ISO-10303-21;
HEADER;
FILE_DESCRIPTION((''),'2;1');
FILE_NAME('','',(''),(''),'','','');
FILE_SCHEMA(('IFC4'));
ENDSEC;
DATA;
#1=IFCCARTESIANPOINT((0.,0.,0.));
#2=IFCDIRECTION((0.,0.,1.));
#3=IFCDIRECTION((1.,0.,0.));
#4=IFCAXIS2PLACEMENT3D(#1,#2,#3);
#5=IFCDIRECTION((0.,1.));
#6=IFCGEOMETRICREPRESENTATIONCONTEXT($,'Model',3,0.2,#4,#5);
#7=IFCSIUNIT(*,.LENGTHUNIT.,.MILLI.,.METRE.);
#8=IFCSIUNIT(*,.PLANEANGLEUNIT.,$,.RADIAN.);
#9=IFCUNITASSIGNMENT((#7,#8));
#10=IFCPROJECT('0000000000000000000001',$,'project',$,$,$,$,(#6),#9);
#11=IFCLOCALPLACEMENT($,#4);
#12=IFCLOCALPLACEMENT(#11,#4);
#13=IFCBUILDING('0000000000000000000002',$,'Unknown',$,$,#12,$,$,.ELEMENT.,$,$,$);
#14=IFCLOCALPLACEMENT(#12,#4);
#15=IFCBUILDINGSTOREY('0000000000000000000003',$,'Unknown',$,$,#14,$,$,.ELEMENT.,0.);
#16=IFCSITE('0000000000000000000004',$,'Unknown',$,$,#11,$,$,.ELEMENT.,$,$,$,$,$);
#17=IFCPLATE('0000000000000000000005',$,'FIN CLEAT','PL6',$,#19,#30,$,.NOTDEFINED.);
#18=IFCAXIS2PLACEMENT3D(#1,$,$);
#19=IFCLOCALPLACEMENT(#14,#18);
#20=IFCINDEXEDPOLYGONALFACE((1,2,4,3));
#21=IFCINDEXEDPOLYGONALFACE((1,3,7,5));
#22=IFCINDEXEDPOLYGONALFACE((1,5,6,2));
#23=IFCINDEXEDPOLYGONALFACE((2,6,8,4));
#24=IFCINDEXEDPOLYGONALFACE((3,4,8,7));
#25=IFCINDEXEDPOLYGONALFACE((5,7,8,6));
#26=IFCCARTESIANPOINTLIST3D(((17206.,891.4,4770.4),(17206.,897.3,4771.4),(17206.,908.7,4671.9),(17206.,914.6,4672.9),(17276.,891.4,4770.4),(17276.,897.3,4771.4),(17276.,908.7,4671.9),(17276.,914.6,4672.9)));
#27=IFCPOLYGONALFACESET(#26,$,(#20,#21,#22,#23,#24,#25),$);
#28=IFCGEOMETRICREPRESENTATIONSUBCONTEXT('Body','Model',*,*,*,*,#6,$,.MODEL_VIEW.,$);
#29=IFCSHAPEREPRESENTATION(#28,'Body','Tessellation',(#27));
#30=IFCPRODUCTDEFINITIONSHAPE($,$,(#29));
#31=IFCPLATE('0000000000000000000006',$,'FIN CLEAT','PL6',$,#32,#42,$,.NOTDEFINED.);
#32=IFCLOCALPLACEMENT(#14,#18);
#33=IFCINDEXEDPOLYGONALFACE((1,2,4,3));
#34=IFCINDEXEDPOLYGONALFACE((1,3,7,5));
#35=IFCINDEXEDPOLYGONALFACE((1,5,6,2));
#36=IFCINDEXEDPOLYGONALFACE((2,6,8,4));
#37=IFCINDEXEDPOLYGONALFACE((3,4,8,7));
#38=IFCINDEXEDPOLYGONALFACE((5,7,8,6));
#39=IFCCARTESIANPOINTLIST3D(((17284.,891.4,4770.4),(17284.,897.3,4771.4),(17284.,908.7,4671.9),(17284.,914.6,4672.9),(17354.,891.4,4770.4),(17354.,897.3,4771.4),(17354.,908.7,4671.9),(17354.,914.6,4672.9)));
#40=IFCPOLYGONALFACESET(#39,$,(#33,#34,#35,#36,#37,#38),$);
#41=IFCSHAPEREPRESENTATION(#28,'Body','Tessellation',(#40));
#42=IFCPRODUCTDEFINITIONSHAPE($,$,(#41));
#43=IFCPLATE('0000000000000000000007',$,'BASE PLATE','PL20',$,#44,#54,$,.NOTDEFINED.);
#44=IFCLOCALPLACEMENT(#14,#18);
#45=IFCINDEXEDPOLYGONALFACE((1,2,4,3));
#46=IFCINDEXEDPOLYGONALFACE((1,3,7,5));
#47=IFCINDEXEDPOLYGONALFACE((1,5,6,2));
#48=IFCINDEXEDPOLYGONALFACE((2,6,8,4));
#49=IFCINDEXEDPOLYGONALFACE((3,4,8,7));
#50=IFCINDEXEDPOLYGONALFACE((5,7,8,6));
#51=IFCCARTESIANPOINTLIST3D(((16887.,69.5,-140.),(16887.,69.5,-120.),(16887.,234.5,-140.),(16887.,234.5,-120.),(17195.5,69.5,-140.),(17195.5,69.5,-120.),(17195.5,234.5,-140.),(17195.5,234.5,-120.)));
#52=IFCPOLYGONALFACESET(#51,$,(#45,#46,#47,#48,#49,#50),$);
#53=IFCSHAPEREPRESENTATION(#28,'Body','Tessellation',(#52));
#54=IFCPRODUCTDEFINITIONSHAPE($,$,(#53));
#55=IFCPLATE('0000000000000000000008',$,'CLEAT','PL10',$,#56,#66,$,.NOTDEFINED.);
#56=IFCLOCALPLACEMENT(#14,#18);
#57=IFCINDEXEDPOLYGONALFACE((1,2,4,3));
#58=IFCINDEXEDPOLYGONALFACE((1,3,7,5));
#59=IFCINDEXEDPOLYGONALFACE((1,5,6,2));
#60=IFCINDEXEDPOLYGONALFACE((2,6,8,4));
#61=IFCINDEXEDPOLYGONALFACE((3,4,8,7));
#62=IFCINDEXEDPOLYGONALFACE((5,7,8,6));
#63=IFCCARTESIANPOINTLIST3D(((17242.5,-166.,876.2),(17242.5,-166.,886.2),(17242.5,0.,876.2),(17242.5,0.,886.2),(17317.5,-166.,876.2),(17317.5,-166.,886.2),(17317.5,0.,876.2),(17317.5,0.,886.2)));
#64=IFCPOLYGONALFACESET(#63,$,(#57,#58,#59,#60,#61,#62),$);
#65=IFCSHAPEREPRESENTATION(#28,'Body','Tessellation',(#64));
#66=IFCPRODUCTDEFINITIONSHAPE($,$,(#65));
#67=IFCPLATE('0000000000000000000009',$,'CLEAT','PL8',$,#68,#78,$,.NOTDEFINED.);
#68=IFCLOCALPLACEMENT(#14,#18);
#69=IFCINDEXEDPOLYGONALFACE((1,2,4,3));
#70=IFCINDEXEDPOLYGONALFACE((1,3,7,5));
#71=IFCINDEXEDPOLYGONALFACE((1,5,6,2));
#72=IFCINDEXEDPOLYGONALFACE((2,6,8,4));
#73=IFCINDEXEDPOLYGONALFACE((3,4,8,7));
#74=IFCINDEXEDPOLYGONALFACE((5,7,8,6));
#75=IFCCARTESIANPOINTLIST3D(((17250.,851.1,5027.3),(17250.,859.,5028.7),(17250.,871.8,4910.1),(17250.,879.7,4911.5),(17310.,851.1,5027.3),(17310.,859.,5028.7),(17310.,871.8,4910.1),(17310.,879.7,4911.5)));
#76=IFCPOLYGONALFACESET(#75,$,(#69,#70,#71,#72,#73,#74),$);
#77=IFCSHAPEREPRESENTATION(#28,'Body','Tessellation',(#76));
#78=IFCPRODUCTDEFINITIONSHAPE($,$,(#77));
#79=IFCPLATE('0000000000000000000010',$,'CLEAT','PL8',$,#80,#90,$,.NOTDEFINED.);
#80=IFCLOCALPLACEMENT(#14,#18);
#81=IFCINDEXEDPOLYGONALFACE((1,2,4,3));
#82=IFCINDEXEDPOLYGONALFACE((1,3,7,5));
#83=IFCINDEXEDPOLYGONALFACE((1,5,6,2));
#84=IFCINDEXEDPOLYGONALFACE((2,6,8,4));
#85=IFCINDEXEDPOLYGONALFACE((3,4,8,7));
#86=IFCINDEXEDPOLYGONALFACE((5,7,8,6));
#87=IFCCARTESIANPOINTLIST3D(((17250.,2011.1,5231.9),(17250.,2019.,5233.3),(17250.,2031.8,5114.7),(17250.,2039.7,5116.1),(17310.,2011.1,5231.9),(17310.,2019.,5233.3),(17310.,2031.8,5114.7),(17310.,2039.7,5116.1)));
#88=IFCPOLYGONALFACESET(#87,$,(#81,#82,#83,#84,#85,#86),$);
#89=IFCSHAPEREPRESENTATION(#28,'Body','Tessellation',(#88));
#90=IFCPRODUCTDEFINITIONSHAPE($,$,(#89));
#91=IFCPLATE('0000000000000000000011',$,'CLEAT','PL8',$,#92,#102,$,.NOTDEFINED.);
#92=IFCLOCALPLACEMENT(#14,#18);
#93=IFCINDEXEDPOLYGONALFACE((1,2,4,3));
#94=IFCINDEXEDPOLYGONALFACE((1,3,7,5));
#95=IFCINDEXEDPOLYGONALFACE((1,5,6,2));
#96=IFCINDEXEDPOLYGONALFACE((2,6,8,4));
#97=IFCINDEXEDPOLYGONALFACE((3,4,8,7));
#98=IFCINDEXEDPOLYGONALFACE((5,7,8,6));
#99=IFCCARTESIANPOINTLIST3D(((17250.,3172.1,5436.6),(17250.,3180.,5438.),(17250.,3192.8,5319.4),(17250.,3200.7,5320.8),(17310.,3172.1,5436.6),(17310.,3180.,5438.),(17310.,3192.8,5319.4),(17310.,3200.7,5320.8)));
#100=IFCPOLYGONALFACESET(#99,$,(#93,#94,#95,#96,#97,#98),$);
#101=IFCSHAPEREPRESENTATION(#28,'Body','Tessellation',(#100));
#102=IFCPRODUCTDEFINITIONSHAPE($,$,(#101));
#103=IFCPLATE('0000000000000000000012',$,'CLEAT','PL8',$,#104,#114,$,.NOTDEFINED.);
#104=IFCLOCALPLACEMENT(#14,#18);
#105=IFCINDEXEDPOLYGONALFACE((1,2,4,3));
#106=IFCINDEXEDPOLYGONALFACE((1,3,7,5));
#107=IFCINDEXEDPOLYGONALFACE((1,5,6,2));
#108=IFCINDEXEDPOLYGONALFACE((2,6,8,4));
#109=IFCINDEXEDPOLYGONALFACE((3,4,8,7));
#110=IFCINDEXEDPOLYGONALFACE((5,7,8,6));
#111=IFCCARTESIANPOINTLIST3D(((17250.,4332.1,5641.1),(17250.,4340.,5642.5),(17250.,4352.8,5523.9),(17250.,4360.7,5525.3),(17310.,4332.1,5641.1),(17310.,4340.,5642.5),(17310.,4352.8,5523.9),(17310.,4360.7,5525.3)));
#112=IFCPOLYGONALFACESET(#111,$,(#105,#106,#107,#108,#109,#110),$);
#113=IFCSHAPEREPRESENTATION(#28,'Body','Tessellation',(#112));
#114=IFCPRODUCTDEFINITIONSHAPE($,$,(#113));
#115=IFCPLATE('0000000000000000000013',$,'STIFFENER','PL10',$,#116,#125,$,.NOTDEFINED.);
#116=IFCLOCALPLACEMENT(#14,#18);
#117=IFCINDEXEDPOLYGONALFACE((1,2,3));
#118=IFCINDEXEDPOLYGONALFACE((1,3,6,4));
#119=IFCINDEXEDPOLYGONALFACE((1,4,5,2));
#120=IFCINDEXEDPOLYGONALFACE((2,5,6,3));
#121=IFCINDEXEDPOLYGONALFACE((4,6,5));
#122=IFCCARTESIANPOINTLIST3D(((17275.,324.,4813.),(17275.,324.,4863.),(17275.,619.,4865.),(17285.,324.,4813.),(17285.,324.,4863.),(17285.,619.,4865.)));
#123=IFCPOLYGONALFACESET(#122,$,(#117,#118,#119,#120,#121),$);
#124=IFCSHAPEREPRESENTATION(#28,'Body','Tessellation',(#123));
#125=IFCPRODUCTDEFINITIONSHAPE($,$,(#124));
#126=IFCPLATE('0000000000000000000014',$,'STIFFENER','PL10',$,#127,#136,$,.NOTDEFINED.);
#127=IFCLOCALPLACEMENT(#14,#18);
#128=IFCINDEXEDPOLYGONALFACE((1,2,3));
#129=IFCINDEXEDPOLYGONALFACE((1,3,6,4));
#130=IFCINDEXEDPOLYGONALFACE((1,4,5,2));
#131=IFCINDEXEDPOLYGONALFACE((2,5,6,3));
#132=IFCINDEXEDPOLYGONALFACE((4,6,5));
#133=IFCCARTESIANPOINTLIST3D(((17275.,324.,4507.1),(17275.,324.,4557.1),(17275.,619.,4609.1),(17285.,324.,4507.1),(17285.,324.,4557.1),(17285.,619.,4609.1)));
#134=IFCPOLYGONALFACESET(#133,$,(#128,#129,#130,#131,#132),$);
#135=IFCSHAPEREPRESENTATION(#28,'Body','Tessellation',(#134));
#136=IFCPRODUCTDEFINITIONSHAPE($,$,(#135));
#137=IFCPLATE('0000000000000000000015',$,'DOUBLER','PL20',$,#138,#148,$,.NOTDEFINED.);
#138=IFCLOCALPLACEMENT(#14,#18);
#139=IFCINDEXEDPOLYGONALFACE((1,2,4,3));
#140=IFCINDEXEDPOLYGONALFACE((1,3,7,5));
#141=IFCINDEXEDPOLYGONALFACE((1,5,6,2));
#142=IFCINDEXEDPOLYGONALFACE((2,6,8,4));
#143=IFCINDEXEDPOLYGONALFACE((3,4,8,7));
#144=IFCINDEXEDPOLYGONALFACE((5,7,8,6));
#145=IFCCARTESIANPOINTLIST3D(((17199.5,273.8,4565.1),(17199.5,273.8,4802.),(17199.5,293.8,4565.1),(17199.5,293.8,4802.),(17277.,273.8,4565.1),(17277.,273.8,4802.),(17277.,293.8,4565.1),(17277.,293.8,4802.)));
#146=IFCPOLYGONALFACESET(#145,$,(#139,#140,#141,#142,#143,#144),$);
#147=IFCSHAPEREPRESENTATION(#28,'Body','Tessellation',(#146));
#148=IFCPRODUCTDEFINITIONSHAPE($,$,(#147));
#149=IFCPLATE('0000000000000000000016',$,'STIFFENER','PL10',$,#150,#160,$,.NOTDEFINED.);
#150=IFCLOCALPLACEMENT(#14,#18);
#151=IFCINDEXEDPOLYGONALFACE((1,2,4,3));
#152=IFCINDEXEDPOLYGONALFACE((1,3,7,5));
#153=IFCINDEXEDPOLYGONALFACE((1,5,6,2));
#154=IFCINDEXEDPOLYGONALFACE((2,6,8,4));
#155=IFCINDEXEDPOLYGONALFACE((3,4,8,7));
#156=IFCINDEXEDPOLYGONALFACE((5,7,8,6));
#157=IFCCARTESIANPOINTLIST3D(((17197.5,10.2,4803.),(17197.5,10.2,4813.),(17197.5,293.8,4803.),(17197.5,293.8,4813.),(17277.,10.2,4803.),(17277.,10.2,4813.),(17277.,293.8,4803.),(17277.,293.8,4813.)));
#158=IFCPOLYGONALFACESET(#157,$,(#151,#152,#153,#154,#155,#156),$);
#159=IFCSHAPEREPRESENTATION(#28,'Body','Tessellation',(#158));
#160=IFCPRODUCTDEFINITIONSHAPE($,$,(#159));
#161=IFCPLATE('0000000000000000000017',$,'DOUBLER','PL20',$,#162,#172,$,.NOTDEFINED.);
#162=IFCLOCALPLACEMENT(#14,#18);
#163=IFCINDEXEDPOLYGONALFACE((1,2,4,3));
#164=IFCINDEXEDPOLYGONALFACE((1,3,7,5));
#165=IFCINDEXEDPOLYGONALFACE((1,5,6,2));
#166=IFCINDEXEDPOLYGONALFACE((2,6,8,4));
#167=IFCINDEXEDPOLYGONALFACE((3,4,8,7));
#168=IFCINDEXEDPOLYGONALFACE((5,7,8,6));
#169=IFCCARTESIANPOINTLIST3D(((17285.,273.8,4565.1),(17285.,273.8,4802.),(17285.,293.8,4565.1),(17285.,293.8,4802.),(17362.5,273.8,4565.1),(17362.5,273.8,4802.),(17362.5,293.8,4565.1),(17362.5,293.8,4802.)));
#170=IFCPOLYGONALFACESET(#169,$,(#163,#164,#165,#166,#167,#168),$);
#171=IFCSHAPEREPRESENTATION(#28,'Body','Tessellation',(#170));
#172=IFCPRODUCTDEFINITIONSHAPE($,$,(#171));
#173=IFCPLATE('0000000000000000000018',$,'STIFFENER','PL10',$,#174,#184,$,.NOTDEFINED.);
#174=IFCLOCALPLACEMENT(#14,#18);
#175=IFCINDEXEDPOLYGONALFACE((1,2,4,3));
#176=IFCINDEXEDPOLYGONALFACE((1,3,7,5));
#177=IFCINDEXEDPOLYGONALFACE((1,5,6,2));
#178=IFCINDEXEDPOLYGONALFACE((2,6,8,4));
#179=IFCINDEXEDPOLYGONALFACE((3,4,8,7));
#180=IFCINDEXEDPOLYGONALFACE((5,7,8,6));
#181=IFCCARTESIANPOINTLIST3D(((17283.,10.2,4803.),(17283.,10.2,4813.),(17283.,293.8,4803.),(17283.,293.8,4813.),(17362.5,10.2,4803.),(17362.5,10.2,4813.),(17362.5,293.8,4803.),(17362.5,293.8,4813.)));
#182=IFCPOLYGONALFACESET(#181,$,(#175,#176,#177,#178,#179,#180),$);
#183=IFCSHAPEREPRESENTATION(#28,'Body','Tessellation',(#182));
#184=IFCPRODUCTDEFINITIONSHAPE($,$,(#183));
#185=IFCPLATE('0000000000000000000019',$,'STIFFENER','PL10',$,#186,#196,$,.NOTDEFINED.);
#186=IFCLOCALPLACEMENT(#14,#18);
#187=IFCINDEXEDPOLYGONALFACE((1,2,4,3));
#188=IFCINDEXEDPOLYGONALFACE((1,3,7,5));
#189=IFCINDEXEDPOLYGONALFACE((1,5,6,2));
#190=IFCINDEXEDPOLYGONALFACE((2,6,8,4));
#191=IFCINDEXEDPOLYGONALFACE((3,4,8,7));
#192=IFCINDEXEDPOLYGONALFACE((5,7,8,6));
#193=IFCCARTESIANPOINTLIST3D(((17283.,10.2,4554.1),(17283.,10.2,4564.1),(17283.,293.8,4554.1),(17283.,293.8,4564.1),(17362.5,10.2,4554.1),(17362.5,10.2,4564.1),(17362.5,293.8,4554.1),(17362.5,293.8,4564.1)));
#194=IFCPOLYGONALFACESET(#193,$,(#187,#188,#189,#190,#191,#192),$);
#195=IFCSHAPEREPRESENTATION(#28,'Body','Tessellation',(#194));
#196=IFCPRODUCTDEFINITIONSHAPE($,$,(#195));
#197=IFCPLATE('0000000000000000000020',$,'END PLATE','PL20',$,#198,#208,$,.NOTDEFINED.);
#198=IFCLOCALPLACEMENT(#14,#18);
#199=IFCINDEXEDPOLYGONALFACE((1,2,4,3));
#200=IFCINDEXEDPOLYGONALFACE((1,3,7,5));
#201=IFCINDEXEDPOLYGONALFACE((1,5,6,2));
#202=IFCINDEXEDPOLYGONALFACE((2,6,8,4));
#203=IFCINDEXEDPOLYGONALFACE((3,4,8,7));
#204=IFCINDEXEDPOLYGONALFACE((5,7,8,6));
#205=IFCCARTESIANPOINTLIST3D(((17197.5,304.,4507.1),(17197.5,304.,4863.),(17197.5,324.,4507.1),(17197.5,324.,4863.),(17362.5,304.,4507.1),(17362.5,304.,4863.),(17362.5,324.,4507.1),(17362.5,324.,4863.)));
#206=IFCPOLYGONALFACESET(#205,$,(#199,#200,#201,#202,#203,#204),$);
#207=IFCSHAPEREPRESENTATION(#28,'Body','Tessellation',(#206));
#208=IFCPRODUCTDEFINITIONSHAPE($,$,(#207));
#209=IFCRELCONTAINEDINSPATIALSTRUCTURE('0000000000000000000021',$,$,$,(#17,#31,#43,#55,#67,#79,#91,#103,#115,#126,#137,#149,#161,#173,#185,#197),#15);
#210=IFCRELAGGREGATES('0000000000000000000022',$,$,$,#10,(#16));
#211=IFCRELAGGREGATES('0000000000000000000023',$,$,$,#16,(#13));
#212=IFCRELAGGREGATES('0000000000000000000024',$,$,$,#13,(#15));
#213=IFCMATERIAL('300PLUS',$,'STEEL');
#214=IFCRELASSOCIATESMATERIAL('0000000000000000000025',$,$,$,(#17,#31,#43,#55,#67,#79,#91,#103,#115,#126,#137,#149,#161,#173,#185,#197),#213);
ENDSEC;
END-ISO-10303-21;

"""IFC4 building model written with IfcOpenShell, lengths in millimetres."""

from ifc_helpers import new_model, si_unit, direction, frame, origin_with_axes, place, context, subcontext, project, spatial, line, indexed_curve, outline, extrude, material, element, save


model = new_model("IFC4")

# Units and contexts
model_context = context("Model", 3, precision=0.2, world=origin_with_axes(), true_north=direction((0.0, 1.0)))
body_context = subcontext(model_context, "Body", "Model", "MODEL_VIEW")
ifc_project = project(units=[si_unit("LENGTHUNIT", "METRE", prefix="MILLI"), si_unit("PLANEANGLEUNIT", "RADIAN")], contexts=[model_context])

# Site, building, storey
site_placement = place(None, origin_with_axes())
site = spatial("IfcSite", under=ifc_project, at=site_placement, Name="Unknown", CompositionType="ELEMENT")
building_placement = place(site_placement, origin_with_axes())
building = spatial("IfcBuilding", under=site, at=building_placement, Name="Unknown", CompositionType="ELEMENT")
storey_placement = place(building_placement, origin_with_axes())
storey = spatial("IfcBuildingStorey", under=building, at=storey_placement, Name="Unknown", CompositionType="ELEMENT", Elevation=0.0)

# Shared definitions
ifc_material_1 = material(Name="300PLUS", Category="STEEL")

# Plates
for number, where, z_axis, x_axis, name in (
    (1, (17206.0, 894.4, 4770.9), (0.0, 0.984924, 0.172987), (1.0, 0.0, 0.0), "FIN CLEAT"),
    (2, (17284.0, 894.4, 4770.9), (0.0, 0.984924, 0.172987), (1.0, 0.0, 0.0), "FIN CLEAT"),
):
    element("IfcPlate", number, at=place(storey_placement, frame(where, z_axis=z_axis, x_axis=x_axis)), inside=storey, material=ifc_material_1, Name=name, Description="PL6", PredefinedType="NOTDEFINED", context=body_context, shape_type="SolidModel", body=[
        extrude(outline(indexed_curve([(0.0, 0.0), (70.0, 0.0), (70.0, 100.0), (0.0, 100.0)], segments=[line(1, 2, 3, 4, 1)])), frame((0.0, 0.0, 3.0), z_axis=(0.0, 0.0, 1.0), x_axis=(1.0, 0.0, 0.0)), (0.0, 0.0, -1.0), 6.0),
    ])
plate_1_placement = place(storey_placement, frame((16887.0, 69.5, -130.0), z_axis=(0.0, 0.0, 1.0), x_axis=(1.0, 0.0, 0.0)))
element("IfcPlate", 3, at=plate_1_placement, inside=storey, material=ifc_material_1, Name="BASE PLATE", Description="PL20", PredefinedType="NOTDEFINED", context=body_context, shape_type="SolidModel", body=[
    extrude(outline(indexed_curve([(0.0, 0.0), (308.5, 0.0), (308.5, 165.0), (0.0, 165.0)], segments=[line(1, 2, 3, 4, 1)])), frame((0.0, 0.0, 10.0), z_axis=(0.0, 0.0, 1.0), x_axis=(1.0, 0.0, 0.0)), (0.0, 0.0, -1.0), 20.0),
])
plate_2_placement = place(storey_placement, frame((17317.5, 0.0, 881.2), z_axis=(0.0, 0.0, 1.0), x_axis=(-1.0, 0.0, 0.0)))
element("IfcPlate", 4, at=plate_2_placement, inside=storey, material=ifc_material_1, Name="CLEAT", Description="PL10", PredefinedType="NOTDEFINED", context=body_context, shape_type="SolidModel", body=[
    extrude(outline(indexed_curve([(0.0, 0.0), (75.0, 0.0), (75.0, 166.0), (0.0, 166.0)], segments=[line(1, 2, 3, 4, 1)])), frame((0.0, 0.0, 5.0), z_axis=(0.0, 0.0, 1.0), x_axis=(1.0, 0.0, 0.0)), (0.0, 0.0, -1.0), 10.0),
])
for number, where, z_axis, x_axis, name in (
    (5, (17310.0, 875.7, 4910.8), (0.0, 0.984758, 0.173929), (-1.0, 0.0, 0.0), "CLEAT"),
    (6, (17310.0, 2035.7, 5115.4), (0.0, 0.984758, 0.173929), (-1.0, 0.0, 0.0), "CLEAT"),
    (7, (17310.0, 3196.7, 5320.1), (0.0, 0.984758, 0.173929), (-1.0, 0.0, 0.0), "CLEAT"),
    (8, (17310.0, 4356.7, 5524.6), (0.0, 0.984758, 0.173929), (-1.0, 0.0, 0.0), "CLEAT"),
):
    element("IfcPlate", number, at=place(storey_placement, frame(where, z_axis=z_axis, x_axis=x_axis)), inside=storey, material=ifc_material_1, Name=name, Description="PL8", PredefinedType="NOTDEFINED", context=body_context, shape_type="SolidModel", body=[
        extrude(outline(indexed_curve([(0.0, 0.0), (60.0, 0.0), (60.0, 119.0), (0.0, 119.0)], segments=[line(1, 2, 3, 4, 1)])), frame((0.0, 0.0, 4.0), z_axis=(0.0, 0.0, 1.0), x_axis=(1.0, 0.0, 0.0)), (0.0, 0.0, -1.0), 8.0),
    ])
plate_3_placement = place(storey_placement, frame((17280.0, 619.0, 4865.0), z_axis=(1.0, 0.0, 0.0), x_axis=(0.0, -0.999977, -0.00678)))
element("IfcPlate", 9, at=plate_3_placement, inside=storey, material=ifc_material_1, Name="STIFFENER", Description="PL10", PredefinedType="NOTDEFINED", context=body_context, shape_type="SolidModel", body=[
    extrude(outline(indexed_curve([(0.0, 0.0), (295.0, 0.0), (295.3, 50.0)], segments=[line(1, 2, 3, 1)])), frame((0.0, 0.0, 5.0), z_axis=(0.0, 0.0, 1.0), x_axis=(1.0, 0.0, 0.0)), (0.0, 0.0, -1.0), 10.0),
])
plate_4_placement = place(storey_placement, frame((17280.0, 619.0, 4609.1), z_axis=(1.0, 0.0, 0.0), x_axis=(0.0, -0.984817, -0.173595)))
element("IfcPlate", 10, at=plate_4_placement, inside=storey, material=ifc_material_1, Name="STIFFENER", Description="PL10", PredefinedType="NOTDEFINED", context=body_context, shape_type="SolidModel", body=[
    extrude(outline(indexed_curve([(0.0, 0.0), (299.5, 0.0), (308.2, 49.2)], segments=[line(1, 2, 3, 1)])), frame((0.0, 0.0, 5.0), z_axis=(0.0, 0.0, 1.0), x_axis=(1.0, 0.0, 0.0)), (0.0, 0.0, -1.0), 10.0),
])
plate_5_placement = place(storey_placement, frame((17199.5, 283.8, 4565.1), z_axis=(0.0, -1.0, 0.0), x_axis=(1.0, 0.0, 0.0)))
element("IfcPlate", 11, at=plate_5_placement, inside=storey, material=ifc_material_1, Name="DOUBLER", Description="PL20", PredefinedType="NOTDEFINED", context=body_context, shape_type="SolidModel", body=[
    extrude(outline(indexed_curve([(0.0, 0.0), (77.5, 0.0), (77.5, 236.9), (0.0, 236.9)], segments=[line(1, 2, 3, 4, 1)])), frame((0.0, 0.0, 10.0), z_axis=(0.0, 0.0, 1.0), x_axis=(1.0, 0.0, 0.0)), (0.0, 0.0, -1.0), 20.0),
])
plate_6_placement = place(storey_placement, frame((17197.5, 10.2, 4808.0), z_axis=(0.0, 0.0, 1.0), x_axis=(1.0, 0.0, 0.0)))
element("IfcPlate", 12, at=plate_6_placement, inside=storey, material=ifc_material_1, Name="STIFFENER", Description="PL10", PredefinedType="NOTDEFINED", context=body_context, shape_type="SolidModel", body=[
    extrude(outline(indexed_curve([(0.0, 0.0), (79.5, 0.0), (79.5, 283.6), (0.0, 283.6)], segments=[line(1, 2, 3, 4, 1)])), frame((0.0, 0.0, 5.0), z_axis=(0.0, 0.0, 1.0), x_axis=(1.0, 0.0, 0.0)), (0.0, 0.0, -1.0), 10.0),
])
plate_7_placement = place(storey_placement, frame((17285.0, 283.8, 4565.1), z_axis=(0.0, -1.0, 0.0), x_axis=(1.0, 0.0, 0.0)))
element("IfcPlate", 13, at=plate_7_placement, inside=storey, material=ifc_material_1, Name="DOUBLER", Description="PL20", PredefinedType="NOTDEFINED", context=body_context, shape_type="SolidModel", body=[
    extrude(outline(indexed_curve([(0.0, 0.0), (77.5, 0.0), (77.5, 236.9), (0.0, 236.9)], segments=[line(1, 2, 3, 4, 1)])), frame((0.0, 0.0, 10.0), z_axis=(0.0, 0.0, 1.0), x_axis=(1.0, 0.0, 0.0)), (0.0, 0.0, -1.0), 20.0),
])
for number, where, z_axis, x_axis, name in (
    (14, (17283.0, 10.2, 4808.0), (0.0, 0.0, 1.0), (1.0, 0.0, 0.0), "STIFFENER"),
    (15, (17283.0, 10.2, 4559.1), (0.0, 0.0, 1.0), (1.0, 0.0, 0.0), "STIFFENER"),
):
    element("IfcPlate", number, at=place(storey_placement, frame(where, z_axis=z_axis, x_axis=x_axis)), inside=storey, material=ifc_material_1, Name=name, Description="PL10", PredefinedType="NOTDEFINED", context=body_context, shape_type="SolidModel", body=[
        extrude(outline(indexed_curve([(0.0, 0.0), (79.5, 0.0), (79.5, 283.6), (0.0, 283.6)], segments=[line(1, 2, 3, 4, 1)])), frame((0.0, 0.0, 5.0), z_axis=(0.0, 0.0, 1.0), x_axis=(1.0, 0.0, 0.0)), (0.0, 0.0, -1.0), 10.0),
    ])
plate_8_placement = place(storey_placement, frame((17197.5, 314.0, 4507.1), z_axis=(0.0, -1.0, 0.0), x_axis=(1.0, 0.0, 0.0)))
element("IfcPlate", 16, at=plate_8_placement, inside=storey, material=ifc_material_1, Name="END PLATE", Description="PL20", PredefinedType="NOTDEFINED", context=body_context, shape_type="SolidModel", body=[
    extrude(outline(indexed_curve([(0.0, 0.0), (165.0, 0.0), (165.0, 355.9), (0.0, 355.9)], segments=[line(1, 2, 3, 4, 1)])), frame((0.0, 0.0, 10.0), z_axis=(0.0, 0.0, 1.0), x_axis=(1.0, 0.0, 0.0)), (0.0, 0.0, -1.0), 20.0),
])

save(model, "model.ifc")
